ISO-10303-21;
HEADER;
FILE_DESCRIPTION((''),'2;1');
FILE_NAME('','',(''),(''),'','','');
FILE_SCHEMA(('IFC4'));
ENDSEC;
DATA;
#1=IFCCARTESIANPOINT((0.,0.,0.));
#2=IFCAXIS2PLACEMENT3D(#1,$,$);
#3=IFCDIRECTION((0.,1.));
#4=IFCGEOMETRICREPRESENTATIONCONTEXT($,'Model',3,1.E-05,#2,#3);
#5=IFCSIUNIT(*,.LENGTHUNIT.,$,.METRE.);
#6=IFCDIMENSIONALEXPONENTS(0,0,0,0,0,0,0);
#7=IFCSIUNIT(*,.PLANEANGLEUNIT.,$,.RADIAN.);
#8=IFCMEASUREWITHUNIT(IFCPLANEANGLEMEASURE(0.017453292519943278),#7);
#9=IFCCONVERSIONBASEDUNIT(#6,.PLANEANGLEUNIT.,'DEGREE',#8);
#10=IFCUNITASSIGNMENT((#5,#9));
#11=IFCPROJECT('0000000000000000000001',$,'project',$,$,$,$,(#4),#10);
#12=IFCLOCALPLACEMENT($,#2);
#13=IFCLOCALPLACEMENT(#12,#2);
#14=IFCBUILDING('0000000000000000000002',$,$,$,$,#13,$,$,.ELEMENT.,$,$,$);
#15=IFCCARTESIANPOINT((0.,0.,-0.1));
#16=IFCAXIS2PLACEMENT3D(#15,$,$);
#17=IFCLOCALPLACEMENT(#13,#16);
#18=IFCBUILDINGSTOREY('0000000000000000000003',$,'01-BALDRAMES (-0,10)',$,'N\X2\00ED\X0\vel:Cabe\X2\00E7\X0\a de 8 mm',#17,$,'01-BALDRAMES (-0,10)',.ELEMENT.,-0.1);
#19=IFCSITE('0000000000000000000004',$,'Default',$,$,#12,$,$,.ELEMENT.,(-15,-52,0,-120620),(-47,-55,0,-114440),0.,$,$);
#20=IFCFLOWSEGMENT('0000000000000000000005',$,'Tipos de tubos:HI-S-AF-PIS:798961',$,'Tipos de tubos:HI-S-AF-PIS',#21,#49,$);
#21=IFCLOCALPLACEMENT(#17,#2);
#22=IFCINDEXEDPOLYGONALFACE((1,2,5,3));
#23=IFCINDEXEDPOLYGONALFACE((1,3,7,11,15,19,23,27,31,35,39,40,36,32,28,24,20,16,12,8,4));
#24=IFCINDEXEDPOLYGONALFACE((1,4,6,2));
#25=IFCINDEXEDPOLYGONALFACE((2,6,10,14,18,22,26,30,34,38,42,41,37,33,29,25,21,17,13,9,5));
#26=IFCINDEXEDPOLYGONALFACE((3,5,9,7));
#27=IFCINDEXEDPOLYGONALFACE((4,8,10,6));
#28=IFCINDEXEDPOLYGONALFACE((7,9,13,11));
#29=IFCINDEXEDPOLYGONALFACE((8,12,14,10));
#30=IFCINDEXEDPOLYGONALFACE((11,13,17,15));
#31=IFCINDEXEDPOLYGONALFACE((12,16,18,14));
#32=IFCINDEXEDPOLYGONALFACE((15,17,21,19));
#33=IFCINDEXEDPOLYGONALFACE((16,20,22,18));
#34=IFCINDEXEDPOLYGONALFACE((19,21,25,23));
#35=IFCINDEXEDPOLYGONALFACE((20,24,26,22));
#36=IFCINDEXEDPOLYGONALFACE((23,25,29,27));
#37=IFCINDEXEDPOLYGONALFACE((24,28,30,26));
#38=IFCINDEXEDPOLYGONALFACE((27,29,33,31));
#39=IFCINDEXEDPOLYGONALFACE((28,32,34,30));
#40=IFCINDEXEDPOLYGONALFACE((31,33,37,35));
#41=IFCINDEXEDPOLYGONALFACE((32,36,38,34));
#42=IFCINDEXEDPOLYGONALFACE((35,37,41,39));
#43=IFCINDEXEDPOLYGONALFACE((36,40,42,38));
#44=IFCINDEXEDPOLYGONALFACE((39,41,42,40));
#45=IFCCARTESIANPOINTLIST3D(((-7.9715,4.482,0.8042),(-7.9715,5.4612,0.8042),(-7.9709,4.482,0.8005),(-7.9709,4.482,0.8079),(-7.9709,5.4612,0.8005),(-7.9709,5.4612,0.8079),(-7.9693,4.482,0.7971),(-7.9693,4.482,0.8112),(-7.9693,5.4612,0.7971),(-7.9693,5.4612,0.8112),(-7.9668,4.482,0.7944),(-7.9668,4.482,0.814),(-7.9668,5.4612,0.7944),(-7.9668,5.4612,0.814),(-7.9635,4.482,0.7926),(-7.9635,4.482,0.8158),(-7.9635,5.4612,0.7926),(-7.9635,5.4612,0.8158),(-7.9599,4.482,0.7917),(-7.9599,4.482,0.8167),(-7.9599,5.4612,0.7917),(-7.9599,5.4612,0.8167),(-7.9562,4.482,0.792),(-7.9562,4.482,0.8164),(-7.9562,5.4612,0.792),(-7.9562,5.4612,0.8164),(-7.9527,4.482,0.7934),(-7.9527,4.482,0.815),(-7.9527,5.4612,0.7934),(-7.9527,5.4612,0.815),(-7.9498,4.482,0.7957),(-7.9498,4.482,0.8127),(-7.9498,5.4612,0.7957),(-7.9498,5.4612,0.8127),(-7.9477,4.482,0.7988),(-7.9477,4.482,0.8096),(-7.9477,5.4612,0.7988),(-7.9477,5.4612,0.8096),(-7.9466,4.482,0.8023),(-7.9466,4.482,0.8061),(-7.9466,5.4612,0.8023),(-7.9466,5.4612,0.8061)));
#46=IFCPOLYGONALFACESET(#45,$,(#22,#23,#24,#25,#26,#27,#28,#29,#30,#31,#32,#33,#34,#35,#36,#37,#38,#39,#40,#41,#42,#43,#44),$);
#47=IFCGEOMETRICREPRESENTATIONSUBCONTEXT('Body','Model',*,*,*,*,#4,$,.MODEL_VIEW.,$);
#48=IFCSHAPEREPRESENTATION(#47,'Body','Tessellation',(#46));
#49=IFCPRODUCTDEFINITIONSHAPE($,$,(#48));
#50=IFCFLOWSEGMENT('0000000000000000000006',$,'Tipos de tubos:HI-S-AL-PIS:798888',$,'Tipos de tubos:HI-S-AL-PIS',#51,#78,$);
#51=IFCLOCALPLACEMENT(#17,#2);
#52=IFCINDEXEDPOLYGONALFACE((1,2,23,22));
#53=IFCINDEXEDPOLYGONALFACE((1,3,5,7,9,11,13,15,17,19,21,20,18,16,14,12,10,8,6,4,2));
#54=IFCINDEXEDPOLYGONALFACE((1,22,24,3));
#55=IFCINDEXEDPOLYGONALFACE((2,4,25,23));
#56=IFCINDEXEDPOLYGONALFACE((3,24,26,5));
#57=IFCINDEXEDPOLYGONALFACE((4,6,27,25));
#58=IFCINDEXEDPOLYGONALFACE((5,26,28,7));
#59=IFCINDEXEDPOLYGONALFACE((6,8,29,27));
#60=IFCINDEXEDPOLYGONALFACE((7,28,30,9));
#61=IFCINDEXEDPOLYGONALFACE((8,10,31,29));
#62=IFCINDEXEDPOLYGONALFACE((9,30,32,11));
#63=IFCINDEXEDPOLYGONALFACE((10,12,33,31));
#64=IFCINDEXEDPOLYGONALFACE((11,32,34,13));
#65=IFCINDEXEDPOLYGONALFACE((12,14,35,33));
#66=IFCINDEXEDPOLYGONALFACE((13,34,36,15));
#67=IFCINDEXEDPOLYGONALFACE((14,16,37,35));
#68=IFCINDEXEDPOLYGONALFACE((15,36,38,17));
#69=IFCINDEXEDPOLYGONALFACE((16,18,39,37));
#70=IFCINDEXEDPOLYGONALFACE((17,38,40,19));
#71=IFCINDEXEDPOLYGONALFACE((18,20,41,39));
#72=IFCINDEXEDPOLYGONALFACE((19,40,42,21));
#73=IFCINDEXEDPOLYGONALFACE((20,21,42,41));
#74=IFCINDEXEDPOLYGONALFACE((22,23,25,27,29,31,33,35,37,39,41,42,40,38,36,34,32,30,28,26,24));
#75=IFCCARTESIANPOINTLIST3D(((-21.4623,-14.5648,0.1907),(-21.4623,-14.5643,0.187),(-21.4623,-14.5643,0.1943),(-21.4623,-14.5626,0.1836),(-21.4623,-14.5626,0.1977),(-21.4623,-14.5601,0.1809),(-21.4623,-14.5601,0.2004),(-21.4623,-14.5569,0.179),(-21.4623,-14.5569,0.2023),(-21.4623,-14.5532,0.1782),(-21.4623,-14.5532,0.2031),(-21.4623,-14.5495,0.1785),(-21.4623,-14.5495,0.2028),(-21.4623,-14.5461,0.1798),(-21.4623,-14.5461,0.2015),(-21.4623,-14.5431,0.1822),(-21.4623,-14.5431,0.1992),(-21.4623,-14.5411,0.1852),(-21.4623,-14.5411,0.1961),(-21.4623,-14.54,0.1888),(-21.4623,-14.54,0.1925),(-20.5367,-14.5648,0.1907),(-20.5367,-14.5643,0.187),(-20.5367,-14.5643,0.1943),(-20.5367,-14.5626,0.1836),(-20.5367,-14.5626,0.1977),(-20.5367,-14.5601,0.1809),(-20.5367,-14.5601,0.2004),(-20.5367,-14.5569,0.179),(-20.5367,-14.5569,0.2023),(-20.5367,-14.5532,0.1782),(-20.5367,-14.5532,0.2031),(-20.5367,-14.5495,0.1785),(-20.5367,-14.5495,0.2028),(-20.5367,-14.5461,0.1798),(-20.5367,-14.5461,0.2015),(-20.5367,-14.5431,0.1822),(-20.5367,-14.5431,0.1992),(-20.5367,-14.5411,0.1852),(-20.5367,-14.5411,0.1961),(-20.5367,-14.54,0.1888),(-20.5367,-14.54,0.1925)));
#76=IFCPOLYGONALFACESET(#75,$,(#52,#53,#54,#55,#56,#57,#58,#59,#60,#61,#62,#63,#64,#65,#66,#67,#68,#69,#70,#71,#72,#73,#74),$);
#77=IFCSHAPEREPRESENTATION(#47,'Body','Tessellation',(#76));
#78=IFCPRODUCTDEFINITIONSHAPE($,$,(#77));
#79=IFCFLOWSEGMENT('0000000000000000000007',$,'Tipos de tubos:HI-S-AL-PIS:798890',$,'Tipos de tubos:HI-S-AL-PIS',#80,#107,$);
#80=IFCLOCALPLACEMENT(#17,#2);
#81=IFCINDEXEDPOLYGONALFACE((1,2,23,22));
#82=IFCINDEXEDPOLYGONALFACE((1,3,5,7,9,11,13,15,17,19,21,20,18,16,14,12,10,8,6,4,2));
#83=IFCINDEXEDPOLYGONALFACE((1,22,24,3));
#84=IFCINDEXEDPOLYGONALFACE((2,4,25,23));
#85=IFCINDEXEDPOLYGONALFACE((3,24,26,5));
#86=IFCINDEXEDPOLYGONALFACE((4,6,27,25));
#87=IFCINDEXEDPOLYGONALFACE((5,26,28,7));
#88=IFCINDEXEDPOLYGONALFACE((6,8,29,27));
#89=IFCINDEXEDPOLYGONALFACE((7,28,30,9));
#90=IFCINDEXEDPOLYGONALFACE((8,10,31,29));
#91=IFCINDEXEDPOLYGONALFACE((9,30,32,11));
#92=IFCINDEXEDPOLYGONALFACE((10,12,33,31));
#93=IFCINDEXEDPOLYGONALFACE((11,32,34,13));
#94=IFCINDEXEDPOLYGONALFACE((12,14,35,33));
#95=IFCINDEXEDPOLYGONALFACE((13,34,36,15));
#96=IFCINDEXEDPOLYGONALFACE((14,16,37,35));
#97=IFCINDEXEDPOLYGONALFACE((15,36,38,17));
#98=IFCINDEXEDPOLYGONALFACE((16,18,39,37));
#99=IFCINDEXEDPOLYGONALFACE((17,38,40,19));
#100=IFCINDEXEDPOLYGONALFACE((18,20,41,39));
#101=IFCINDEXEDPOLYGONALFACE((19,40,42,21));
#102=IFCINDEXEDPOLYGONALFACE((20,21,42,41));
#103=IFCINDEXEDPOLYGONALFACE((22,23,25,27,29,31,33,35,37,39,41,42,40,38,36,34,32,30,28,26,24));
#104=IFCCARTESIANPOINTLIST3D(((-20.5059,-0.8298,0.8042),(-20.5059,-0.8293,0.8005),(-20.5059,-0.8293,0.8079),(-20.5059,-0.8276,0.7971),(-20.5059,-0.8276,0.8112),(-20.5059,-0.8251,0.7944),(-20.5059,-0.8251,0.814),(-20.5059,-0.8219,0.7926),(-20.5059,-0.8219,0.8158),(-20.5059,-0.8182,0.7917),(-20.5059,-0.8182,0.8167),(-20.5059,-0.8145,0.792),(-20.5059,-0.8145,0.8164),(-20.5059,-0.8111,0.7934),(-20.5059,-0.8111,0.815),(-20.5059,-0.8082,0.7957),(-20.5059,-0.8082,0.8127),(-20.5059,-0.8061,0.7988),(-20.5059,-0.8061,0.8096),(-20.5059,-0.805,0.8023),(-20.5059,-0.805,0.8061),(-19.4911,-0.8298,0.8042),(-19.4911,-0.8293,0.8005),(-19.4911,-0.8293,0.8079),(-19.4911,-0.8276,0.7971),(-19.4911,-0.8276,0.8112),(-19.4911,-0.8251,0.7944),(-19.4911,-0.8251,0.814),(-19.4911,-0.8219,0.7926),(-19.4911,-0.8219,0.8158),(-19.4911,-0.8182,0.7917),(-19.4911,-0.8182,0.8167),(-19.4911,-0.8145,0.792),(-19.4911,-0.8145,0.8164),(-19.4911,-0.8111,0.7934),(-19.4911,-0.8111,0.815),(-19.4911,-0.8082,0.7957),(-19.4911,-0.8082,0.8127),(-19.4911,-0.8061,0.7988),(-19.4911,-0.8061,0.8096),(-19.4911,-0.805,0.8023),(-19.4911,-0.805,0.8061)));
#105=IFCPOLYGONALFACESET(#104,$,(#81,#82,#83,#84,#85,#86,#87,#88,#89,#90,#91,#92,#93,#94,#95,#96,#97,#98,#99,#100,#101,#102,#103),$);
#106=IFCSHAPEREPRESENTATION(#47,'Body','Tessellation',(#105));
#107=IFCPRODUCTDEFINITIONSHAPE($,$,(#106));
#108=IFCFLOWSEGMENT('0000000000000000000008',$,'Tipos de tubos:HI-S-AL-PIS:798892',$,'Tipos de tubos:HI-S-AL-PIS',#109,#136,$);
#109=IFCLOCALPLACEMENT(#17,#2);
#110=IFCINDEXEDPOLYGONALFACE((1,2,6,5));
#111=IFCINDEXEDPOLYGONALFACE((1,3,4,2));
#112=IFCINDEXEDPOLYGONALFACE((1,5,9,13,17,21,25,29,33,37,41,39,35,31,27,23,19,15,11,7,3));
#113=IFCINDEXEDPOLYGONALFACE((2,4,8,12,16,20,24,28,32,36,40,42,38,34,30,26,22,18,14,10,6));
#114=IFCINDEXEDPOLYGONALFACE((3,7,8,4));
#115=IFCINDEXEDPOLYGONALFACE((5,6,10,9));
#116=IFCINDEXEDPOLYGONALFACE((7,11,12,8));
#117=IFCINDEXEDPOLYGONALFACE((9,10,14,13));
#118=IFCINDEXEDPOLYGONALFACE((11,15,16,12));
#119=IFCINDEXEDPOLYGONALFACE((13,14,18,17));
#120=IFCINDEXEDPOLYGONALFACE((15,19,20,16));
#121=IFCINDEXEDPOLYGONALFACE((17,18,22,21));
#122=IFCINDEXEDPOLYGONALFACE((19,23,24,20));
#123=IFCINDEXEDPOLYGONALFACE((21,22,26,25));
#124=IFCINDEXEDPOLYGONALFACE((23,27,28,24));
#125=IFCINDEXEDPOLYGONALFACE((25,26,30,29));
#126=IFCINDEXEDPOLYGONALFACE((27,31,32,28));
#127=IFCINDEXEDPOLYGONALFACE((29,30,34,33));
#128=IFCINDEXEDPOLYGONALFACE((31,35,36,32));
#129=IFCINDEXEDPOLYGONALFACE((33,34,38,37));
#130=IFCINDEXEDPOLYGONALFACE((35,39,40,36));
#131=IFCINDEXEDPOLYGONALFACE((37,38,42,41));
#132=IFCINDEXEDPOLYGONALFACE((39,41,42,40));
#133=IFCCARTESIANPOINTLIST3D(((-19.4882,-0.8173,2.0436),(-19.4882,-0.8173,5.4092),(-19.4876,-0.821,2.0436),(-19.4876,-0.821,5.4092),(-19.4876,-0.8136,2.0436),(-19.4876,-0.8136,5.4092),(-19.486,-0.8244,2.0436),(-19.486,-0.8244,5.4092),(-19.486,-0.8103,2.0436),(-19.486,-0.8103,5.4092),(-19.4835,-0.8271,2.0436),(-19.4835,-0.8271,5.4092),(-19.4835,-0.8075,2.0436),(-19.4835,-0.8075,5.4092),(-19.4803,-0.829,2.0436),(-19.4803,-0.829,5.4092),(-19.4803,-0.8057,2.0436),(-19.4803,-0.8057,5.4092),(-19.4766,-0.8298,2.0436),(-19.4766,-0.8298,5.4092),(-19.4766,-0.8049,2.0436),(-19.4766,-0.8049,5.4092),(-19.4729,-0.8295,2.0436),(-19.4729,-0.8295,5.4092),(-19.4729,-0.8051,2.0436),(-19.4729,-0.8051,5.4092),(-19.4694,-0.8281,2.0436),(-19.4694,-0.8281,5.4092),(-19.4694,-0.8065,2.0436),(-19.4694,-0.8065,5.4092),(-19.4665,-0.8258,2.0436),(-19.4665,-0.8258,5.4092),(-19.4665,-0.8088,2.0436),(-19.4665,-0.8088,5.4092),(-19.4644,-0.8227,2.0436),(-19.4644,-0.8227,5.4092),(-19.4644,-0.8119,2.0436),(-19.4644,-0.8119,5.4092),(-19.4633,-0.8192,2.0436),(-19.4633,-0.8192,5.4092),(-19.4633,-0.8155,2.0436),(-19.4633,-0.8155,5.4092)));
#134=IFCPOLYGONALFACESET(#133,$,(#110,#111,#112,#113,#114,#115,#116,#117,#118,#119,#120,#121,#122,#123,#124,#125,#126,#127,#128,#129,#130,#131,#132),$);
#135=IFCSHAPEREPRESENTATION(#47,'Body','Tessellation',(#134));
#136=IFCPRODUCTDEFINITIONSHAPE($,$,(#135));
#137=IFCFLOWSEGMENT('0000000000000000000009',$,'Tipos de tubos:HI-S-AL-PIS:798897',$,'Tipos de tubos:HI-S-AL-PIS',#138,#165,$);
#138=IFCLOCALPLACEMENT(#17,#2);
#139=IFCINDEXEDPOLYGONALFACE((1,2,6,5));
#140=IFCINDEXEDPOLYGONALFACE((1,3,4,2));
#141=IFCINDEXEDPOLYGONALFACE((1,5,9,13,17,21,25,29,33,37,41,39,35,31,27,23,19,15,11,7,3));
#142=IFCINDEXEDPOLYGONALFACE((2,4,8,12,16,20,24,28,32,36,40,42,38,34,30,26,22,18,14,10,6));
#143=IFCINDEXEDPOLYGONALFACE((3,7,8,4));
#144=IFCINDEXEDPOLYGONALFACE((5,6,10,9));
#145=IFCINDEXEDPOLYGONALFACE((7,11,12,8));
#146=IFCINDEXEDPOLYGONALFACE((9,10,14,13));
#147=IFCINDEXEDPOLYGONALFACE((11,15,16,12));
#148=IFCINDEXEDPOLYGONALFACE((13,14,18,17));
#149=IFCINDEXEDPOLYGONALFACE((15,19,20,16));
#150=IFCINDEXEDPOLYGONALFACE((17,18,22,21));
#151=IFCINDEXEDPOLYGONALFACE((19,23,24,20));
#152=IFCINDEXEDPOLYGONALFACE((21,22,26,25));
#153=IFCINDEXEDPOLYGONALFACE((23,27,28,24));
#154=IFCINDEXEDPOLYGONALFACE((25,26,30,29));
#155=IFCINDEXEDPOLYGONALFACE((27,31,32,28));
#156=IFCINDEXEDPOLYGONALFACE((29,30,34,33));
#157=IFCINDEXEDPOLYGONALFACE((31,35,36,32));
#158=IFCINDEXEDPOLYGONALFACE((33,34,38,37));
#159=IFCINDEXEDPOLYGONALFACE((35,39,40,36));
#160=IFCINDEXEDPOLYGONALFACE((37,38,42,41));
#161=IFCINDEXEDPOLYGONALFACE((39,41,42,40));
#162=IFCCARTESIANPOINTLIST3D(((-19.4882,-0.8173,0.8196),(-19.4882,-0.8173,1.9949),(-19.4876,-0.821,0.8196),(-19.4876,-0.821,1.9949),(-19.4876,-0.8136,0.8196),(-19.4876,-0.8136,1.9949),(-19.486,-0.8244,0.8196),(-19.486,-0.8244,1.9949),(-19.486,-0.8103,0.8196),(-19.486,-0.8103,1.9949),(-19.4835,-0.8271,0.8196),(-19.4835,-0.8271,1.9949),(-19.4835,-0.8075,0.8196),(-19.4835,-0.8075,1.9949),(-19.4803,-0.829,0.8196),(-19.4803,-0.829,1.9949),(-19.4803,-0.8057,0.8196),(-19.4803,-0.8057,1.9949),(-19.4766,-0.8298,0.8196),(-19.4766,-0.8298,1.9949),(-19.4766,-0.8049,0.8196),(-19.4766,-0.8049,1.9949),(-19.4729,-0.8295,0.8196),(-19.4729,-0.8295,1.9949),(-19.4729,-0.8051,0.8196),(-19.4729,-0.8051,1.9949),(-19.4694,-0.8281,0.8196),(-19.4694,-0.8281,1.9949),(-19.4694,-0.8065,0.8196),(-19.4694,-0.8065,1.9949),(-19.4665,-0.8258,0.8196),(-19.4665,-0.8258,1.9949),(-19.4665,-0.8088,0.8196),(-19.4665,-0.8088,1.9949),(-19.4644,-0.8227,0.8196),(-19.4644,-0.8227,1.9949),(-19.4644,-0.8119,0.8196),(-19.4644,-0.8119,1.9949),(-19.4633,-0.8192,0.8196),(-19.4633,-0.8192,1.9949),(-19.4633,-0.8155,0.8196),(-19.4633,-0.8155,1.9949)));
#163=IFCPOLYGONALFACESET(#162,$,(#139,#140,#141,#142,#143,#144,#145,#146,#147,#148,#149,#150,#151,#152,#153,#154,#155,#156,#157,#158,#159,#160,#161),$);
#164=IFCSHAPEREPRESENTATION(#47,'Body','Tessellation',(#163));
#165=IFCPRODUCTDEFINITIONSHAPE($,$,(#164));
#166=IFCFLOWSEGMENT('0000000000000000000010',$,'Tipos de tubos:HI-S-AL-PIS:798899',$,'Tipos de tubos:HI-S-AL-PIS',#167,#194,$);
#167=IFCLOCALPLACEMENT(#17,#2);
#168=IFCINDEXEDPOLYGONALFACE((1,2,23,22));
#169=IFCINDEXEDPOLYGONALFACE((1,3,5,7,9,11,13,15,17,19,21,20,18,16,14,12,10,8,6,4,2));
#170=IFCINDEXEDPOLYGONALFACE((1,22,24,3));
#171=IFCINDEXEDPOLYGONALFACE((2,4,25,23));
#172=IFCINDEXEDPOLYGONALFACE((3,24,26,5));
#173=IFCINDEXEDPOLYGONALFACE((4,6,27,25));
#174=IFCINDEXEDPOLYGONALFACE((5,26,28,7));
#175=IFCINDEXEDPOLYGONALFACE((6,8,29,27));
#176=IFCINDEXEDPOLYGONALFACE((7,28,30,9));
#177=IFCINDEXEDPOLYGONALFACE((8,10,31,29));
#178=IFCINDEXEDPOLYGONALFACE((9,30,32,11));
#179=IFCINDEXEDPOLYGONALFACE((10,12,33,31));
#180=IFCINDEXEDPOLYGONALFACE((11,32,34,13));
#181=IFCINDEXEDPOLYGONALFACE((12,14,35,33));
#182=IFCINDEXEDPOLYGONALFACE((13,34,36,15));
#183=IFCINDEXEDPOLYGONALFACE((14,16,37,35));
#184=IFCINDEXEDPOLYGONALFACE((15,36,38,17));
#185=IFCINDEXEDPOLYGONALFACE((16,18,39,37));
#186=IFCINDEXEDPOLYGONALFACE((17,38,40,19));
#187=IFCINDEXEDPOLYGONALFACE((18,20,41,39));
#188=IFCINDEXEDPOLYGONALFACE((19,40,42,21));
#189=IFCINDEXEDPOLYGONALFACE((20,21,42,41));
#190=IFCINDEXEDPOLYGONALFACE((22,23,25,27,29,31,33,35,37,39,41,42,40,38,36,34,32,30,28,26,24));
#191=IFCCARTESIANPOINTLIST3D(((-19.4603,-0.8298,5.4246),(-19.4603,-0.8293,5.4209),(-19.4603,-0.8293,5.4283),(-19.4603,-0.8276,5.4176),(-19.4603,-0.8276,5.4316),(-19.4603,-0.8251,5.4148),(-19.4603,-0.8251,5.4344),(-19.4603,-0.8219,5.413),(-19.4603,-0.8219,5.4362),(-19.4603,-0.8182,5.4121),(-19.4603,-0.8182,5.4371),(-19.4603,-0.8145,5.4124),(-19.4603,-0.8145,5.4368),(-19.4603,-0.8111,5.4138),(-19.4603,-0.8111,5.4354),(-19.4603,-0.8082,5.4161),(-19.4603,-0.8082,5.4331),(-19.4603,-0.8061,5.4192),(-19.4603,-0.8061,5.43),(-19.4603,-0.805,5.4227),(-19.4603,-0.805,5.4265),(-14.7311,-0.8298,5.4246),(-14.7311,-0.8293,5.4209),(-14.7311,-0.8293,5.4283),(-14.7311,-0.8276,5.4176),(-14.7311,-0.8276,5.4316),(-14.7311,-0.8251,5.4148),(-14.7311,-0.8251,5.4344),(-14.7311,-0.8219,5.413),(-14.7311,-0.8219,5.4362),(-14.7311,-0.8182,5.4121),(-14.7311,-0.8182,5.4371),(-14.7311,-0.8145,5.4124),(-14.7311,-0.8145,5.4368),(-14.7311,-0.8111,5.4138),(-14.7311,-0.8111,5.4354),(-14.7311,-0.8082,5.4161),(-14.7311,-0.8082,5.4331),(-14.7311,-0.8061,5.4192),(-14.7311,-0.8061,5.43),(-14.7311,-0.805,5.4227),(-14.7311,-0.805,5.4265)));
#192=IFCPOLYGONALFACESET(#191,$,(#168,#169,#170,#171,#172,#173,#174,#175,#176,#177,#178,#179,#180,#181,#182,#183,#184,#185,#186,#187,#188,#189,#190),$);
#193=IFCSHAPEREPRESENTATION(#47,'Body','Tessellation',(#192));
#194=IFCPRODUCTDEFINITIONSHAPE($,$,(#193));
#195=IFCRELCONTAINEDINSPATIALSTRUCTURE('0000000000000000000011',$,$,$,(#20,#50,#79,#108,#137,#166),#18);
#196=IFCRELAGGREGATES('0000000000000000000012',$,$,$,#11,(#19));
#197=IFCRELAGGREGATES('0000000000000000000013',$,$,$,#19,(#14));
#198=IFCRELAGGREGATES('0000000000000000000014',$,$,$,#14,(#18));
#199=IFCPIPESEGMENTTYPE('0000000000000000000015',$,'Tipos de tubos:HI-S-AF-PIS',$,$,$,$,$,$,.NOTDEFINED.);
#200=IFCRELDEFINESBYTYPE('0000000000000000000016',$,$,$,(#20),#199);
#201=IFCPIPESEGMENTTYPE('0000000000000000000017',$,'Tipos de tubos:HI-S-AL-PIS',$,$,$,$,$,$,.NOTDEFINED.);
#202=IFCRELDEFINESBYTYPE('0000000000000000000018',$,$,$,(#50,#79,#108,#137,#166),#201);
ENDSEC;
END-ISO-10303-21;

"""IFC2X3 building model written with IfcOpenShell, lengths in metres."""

from ifc_helpers import new_model, entity, si_unit, converted_unit, direction, frame, frame_2d, origin, origin_2d_with_axis, place, context, subcontext, project, spatial, circle, extrude, type_object, element, save


model = new_model("IFC2X3")

# Units and contexts
model_context = context("Model", 3, precision=1e-05, world=origin(), true_north=direction((0.0, 1.0)))
body_context = subcontext(model_context, "Body", "Model", "MODEL_VIEW")
ifc_project = project(units=[si_unit("LENGTHUNIT", "METRE"), converted_unit("PLANEANGLEUNIT", "DEGREE", entity("IfcPlaneAngleMeasure", 0.017453292519943278), si_unit("PLANEANGLEUNIT", "RADIAN"), dimensions=[0, 0, 0, 0, 0, 0, 0])], contexts=[model_context])

# Site, building, storey
site_placement = place(None, origin())
site = spatial("IfcSite", under=ifc_project, at=site_placement, Name="Default", CompositionType="ELEMENT", RefLatitude=(-15, -52, 0, -120620), RefLongitude=(-47, -55, 0, -114440), RefElevation=0.0)
building_placement = place(site_placement, origin())
building = spatial("IfcBuilding", under=site, at=building_placement, CompositionType="ELEMENT")
storey_placement = place(building_placement, frame((0.0, 0.0, -0.1)))
storey = spatial("IfcBuildingStorey", under=building, at=storey_placement, Name="01-BALDRAMES (-0,10)", ObjectType="Nível:Cabeça de 8 mm", LongName="01-BALDRAMES (-0,10)", CompositionType="ELEMENT", Elevation=-0.1)

# Flow segments
pipe_segment_type_1 = type_object("IfcPipeSegmentType", Name="Tipos de tubos:HI-S-AF-PIS", PredefinedType="NOTDEFINED")
flow_segment_1_placement = place(storey_placement, origin())
element("IfcFlowSegment", 1, at=flow_segment_1_placement, inside=storey, type_object=pipe_segment_type_1, Name="Tipos de tubos:HI-S-AF-PIS:798961", ObjectType="Tipos de tubos:HI-S-AF-PIS", context=body_context, shape_type="SweptSolid", body=[
    extrude(circle(Radius=0.0125, at=origin_2d_with_axis()), frame((-7.959, 4.482, 0.8042), z_axis=(0.0, 1.0, 0.0), x_axis=(-1.0, 0.0, 0.0)), (0.0, 0.0, 1.0), 0.9792),
])
pipe_segment_type_2 = type_object("IfcPipeSegmentType", Name="Tipos de tubos:HI-S-AL-PIS", PredefinedType="NOTDEFINED")
flow_segment_2_placement = place(storey_placement, origin())
element("IfcFlowSegment", 2, at=flow_segment_2_placement, inside=storey, type_object=pipe_segment_type_2, Name="Tipos de tubos:HI-S-AL-PIS:798888", ObjectType="Tipos de tubos:HI-S-AL-PIS", context=body_context, shape_type="SweptSolid", body=[
    extrude(circle(Radius=0.0125, at=origin_2d_with_axis()), frame((-21.4623, -14.5523, 0.1907), z_axis=(1.0, 0.0, 0.0), x_axis=(0.0, -1.0, 0.0)), (0.0, 0.0, 1.0), 0.9256),
])
flow_segment_3_placement = place(storey_placement, origin())
element("IfcFlowSegment", 3, at=flow_segment_3_placement, inside=storey, type_object=pipe_segment_type_2, Name="Tipos de tubos:HI-S-AL-PIS:798890", ObjectType="Tipos de tubos:HI-S-AL-PIS", context=body_context, shape_type="SweptSolid", body=[
    extrude(circle(Radius=0.0125, at=frame_2d((0.0, 0.0), x_axis=(1.0, 0.0))), frame((-20.5059, -0.8173, 0.8042), z_axis=(1.0, 0.0, 0.0), x_axis=(0.0, -1.0, 0.0)), (0.0, 0.0, 1.0), 1.0148),
])
flow_segment_4_placement = place(storey_placement, origin())
element("IfcFlowSegment", 4, at=flow_segment_4_placement, inside=storey, type_object=pipe_segment_type_2, Name="Tipos de tubos:HI-S-AL-PIS:798892", ObjectType="Tipos de tubos:HI-S-AL-PIS", context=body_context, shape_type="SweptSolid", body=[
    extrude(circle(Radius=0.0125, at=frame_2d((0.0, 0.0), x_axis=(1.0, 0.0))), frame((-19.4757, -0.8173, 2.0436), z_axis=(0.0, 0.0, 1.0), x_axis=(-1.0, 0.0, 0.0)), (0.0, 0.0, 1.0), 3.3656),
])
flow_segment_5_placement = place(storey_placement, origin())
element("IfcFlowSegment", 5, at=flow_segment_5_placement, inside=storey, type_object=pipe_segment_type_2, Name="Tipos de tubos:HI-S-AL-PIS:798897", ObjectType="Tipos de tubos:HI-S-AL-PIS", context=body_context, shape_type="SweptSolid", body=[
    extrude(circle(Radius=0.0125, at=frame_2d((0.0, 0.0), x_axis=(1.0, 0.0))), frame((-19.4757, -0.8173, 0.8196), z_axis=(0.0, 0.0, 1.0), x_axis=(-1.0, 0.0, 0.0)), (0.0, 0.0, 1.0), 1.1753),
])
flow_segment_6_placement = place(storey_placement, origin())
element("IfcFlowSegment", 6, at=flow_segment_6_placement, inside=storey, type_object=pipe_segment_type_2, Name="Tipos de tubos:HI-S-AL-PIS:798899", ObjectType="Tipos de tubos:HI-S-AL-PIS", context=body_context, shape_type="SweptSolid", body=[
    extrude(circle(Radius=0.0125, at=origin_2d_with_axis()), frame((-19.4603, -0.8173, 5.4246), z_axis=(1.0, 0.0, 0.0), x_axis=(0.0, -1.0, 0.0)), (0.0, 0.0, 1.0), 4.7292),
])

save(model, "model.ifc")
